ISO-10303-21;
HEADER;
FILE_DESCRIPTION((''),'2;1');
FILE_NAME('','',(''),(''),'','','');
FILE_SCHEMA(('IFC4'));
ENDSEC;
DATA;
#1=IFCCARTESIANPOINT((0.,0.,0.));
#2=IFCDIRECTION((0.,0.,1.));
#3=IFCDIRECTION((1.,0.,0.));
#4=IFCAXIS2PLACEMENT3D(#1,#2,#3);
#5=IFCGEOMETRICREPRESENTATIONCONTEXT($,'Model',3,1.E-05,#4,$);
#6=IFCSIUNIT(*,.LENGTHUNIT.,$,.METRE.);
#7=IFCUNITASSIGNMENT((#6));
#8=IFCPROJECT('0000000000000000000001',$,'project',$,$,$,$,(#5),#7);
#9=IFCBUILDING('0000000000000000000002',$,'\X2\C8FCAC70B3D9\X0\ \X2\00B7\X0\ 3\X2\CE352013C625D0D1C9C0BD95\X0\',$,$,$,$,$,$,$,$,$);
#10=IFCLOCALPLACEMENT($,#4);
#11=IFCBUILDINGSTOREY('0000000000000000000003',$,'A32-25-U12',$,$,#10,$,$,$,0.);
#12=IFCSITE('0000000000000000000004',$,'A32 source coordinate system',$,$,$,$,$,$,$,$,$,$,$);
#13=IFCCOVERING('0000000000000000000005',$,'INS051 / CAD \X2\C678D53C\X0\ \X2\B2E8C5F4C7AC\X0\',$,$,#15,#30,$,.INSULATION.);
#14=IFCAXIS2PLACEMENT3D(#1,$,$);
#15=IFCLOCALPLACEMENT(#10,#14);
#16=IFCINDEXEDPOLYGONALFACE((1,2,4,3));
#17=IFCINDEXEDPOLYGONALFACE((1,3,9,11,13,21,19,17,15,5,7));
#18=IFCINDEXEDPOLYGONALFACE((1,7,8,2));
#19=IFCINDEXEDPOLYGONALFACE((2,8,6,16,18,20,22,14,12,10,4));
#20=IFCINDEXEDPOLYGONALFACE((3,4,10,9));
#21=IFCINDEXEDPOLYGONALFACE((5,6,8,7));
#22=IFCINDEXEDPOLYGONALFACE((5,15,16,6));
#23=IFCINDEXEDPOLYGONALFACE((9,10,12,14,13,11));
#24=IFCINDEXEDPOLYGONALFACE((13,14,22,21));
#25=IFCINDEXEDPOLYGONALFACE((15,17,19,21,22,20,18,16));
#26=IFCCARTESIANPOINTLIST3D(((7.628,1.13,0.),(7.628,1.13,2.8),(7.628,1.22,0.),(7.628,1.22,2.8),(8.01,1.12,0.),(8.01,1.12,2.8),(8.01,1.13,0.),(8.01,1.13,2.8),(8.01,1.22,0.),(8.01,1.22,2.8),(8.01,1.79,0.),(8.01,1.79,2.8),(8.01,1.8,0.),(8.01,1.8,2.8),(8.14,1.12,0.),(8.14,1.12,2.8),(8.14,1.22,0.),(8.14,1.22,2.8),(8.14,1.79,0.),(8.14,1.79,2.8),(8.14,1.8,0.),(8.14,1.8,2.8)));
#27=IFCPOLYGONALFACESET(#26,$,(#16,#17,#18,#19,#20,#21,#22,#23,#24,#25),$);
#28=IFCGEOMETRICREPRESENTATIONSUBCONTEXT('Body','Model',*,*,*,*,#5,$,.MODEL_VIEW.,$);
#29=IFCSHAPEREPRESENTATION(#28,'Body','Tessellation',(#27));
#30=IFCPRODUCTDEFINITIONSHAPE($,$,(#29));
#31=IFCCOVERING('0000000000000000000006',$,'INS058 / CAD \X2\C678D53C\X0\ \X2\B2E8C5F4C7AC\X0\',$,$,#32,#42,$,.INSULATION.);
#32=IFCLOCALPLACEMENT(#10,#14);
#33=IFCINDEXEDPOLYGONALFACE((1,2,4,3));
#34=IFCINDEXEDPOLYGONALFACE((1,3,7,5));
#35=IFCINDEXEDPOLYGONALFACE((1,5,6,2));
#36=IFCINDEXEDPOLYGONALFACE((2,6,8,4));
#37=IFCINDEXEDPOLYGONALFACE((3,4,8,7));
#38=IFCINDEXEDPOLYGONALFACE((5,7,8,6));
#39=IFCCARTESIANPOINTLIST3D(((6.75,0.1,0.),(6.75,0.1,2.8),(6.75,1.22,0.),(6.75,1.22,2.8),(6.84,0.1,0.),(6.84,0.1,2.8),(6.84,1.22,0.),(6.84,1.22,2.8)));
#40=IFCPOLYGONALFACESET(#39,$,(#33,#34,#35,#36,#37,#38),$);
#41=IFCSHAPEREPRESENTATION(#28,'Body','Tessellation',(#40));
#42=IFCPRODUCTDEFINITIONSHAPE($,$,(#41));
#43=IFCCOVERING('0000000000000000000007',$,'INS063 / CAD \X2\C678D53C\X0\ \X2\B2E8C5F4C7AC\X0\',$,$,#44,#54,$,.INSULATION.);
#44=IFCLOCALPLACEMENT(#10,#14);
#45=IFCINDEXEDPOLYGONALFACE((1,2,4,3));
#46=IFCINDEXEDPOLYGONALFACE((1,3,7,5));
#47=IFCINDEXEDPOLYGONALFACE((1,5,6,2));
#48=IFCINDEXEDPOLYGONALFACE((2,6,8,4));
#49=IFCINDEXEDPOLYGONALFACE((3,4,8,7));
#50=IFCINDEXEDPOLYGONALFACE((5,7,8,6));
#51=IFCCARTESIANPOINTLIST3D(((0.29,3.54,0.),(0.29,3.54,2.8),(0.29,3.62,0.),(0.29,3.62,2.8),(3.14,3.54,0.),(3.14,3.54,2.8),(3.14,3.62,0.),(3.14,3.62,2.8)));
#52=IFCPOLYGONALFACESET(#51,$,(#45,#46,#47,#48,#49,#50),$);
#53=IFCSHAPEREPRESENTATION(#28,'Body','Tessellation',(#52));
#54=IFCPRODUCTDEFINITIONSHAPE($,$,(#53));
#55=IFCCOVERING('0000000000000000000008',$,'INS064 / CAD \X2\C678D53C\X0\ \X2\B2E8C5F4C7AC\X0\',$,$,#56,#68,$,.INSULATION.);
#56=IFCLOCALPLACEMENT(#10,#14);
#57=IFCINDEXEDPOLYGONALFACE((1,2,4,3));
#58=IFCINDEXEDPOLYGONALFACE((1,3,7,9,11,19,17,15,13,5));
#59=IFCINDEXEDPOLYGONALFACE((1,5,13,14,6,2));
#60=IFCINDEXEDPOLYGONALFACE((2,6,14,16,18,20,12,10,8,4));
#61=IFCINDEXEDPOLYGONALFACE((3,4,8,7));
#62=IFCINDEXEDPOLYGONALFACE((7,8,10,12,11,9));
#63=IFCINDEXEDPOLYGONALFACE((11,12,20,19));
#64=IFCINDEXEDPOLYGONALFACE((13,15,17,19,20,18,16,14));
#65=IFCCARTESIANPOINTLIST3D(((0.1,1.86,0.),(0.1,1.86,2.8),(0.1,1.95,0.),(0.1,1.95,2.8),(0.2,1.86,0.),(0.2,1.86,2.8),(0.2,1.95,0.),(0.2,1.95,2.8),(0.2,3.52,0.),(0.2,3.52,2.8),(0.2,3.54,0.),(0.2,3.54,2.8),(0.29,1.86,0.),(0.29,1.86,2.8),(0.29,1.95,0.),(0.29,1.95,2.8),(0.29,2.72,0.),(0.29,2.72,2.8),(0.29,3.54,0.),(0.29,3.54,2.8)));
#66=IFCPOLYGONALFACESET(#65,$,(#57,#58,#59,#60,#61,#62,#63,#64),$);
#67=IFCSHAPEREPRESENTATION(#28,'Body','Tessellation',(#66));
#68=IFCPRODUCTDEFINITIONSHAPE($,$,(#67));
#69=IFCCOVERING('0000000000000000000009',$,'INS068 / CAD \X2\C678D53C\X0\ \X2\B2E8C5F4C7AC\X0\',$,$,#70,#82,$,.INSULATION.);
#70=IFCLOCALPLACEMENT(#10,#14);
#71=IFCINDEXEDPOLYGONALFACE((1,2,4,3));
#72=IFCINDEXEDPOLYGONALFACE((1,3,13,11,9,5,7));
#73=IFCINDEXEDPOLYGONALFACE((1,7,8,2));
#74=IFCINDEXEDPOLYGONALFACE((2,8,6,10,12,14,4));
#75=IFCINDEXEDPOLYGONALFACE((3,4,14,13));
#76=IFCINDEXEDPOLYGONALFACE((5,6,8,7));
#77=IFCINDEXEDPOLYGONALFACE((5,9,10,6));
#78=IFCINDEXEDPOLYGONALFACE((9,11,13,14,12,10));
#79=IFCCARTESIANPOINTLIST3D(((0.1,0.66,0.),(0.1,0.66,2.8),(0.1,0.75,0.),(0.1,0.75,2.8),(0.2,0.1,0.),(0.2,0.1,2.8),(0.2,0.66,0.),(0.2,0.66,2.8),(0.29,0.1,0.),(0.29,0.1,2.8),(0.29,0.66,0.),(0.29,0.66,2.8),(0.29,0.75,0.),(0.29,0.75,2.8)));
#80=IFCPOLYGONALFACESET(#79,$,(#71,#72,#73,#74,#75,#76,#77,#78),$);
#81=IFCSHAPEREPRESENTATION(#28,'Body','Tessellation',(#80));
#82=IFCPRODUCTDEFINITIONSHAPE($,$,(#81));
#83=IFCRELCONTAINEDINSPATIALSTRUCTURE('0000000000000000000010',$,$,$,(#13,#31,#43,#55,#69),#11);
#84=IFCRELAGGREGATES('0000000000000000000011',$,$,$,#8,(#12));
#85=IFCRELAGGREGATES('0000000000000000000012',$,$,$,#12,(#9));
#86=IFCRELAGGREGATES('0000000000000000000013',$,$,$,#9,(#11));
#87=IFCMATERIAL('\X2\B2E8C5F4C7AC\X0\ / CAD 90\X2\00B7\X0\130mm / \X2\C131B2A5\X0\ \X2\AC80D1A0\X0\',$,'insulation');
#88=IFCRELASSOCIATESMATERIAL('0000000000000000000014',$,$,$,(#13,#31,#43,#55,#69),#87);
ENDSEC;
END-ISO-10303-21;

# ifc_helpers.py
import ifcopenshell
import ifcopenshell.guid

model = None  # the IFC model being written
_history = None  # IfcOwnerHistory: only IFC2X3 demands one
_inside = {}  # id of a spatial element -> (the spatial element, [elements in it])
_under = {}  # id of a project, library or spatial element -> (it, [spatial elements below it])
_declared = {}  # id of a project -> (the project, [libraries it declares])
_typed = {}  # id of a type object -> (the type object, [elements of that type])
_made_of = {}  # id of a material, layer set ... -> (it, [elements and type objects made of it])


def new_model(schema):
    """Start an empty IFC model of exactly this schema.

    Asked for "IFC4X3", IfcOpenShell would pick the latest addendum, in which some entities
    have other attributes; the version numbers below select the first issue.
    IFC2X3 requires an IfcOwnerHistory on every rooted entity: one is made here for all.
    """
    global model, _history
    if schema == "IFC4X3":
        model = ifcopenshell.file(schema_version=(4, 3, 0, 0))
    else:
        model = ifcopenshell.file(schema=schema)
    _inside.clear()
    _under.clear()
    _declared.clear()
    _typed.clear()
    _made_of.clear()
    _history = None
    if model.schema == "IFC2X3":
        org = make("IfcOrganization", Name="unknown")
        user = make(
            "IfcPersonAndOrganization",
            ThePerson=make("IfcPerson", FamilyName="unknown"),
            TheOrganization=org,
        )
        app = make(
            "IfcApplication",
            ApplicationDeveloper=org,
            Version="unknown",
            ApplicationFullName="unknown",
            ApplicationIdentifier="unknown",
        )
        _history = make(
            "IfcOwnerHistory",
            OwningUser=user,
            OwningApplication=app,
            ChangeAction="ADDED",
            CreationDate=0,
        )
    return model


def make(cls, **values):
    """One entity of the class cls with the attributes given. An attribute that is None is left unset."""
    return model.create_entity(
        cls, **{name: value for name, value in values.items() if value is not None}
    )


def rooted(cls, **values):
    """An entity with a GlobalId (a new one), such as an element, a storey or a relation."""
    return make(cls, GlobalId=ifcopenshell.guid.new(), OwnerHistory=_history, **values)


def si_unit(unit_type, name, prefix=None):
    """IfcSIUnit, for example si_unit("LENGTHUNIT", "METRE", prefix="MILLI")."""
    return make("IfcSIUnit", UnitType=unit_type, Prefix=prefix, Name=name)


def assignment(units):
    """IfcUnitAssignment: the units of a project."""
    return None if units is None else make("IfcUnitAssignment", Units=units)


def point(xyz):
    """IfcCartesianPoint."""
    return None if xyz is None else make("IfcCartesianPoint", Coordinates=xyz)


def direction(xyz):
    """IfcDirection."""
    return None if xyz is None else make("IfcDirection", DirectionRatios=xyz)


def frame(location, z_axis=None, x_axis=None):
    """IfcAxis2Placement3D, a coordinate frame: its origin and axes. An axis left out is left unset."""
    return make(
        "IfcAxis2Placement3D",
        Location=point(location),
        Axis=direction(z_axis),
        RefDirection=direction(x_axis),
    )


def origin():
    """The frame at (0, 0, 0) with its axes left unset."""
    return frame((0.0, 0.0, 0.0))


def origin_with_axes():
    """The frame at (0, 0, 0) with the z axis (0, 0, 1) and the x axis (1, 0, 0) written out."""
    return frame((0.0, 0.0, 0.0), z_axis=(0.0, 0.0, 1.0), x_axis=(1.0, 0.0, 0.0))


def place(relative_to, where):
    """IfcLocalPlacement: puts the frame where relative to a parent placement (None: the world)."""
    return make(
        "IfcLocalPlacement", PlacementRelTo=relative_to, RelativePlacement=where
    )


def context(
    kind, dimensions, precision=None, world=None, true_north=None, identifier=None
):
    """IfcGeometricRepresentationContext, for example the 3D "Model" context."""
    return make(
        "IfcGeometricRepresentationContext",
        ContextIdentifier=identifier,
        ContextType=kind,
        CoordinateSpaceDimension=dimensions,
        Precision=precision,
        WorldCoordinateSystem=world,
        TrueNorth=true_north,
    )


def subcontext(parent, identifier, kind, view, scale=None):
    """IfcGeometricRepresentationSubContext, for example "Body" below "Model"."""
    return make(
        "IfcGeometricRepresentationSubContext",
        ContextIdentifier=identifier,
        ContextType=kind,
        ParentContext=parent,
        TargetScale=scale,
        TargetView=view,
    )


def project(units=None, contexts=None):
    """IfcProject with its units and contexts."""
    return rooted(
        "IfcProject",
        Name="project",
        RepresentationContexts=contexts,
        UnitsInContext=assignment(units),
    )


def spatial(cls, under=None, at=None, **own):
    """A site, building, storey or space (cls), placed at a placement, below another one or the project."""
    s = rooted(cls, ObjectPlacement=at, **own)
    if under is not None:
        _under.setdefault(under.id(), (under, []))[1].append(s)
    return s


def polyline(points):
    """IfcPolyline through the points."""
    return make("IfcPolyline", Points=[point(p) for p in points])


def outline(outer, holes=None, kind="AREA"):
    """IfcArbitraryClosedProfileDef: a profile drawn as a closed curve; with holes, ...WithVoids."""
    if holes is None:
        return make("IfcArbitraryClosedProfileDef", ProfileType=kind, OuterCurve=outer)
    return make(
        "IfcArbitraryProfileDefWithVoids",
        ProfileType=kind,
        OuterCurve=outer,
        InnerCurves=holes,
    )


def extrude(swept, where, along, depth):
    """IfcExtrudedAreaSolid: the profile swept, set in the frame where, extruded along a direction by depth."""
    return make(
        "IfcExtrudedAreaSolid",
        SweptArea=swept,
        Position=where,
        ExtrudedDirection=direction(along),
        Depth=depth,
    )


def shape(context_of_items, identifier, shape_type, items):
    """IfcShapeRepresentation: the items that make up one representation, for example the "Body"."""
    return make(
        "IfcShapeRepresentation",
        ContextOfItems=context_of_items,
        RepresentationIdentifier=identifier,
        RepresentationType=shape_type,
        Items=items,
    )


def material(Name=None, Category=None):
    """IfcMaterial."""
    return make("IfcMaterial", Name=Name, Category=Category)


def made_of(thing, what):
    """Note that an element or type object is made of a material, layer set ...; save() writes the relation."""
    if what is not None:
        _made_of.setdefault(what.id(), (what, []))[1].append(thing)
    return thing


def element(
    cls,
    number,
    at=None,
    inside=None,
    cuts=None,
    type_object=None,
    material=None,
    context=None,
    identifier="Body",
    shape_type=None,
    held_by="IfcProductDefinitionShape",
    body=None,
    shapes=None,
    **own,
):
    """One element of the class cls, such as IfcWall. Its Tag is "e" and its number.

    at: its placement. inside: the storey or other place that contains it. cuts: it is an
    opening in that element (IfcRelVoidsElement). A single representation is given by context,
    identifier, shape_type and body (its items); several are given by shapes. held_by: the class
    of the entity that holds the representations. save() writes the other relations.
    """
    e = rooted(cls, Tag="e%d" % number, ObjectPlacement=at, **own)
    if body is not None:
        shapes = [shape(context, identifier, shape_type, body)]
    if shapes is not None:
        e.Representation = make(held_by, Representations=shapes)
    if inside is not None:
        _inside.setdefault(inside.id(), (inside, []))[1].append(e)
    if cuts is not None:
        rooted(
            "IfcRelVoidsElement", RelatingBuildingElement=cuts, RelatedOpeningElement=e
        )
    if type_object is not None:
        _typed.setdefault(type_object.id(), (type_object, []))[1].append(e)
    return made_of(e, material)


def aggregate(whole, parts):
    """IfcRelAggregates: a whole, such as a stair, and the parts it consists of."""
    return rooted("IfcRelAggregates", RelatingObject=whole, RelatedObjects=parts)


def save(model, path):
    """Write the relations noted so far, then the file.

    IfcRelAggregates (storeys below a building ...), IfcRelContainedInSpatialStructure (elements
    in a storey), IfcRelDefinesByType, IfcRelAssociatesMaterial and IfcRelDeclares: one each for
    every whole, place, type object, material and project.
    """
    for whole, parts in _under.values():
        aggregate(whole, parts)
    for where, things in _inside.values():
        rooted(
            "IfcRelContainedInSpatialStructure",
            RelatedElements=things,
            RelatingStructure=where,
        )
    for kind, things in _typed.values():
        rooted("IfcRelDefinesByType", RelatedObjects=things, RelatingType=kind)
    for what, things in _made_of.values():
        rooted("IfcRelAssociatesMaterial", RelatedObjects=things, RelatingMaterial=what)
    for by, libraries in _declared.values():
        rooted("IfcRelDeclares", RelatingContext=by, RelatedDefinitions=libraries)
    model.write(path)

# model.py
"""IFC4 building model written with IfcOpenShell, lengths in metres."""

from ifc_helpers import new_model, si_unit, origin, origin_with_axes, place, context, subcontext, project, spatial, polyline, outline, extrude, material, element, save


model = new_model("IFC4")

# Units and contexts
model_context = context("Model", 3, precision=1e-05, world=origin_with_axes())
body_context = subcontext(model_context, "Body", "Model", "MODEL_VIEW")
ifc_project = project(units=[si_unit("LENGTHUNIT", "METRE")], contexts=[model_context])

# Site, building, storey
storey_placement = place(None, origin_with_axes())
site = spatial("IfcSite", under=ifc_project, Name="A32 source coordinate system")
building = spatial("IfcBuilding", under=site, Name="주거동 · 3층–옥탑지붕")
storey = spatial("IfcBuildingStorey", under=building, at=storey_placement, Name="A32-25-U12", Elevation=0.0)

# Coverings
ifc_material = material(Name="단열재 / CAD 90·130mm / 성능 검토", Category="insulation")
covering_1_placement = place(storey_placement, origin_with_axes())
element("IfcCovering", 1, at=covering_1_placement, inside=storey, material=ifc_material, Name="INS051 / CAD 외피 단열재", PredefinedType="INSULATION", context=body_context, shape_type="SweptSolid", body=[
    extrude(outline(polyline([(8.14, 1.12), (8.01, 1.12), (8.01, 1.13), (7.628, 1.13), (7.628, 1.22), (8.01, 1.22), (8.01, 1.79), (8.01, 1.8), (8.14, 1.8), (8.14, 1.79), (8.14, 1.22), (8.14, 1.12)])), origin(), (0.0, 0.0, 1.0), 2.8),
])
covering_2_placement = place(storey_placement, origin_with_axes())
element("IfcCovering", 2, at=covering_2_placement, inside=storey, material=ifc_material, Name="INS058 / CAD 외피 단열재", PredefinedType="INSULATION", context=body_context, shape_type="SweptSolid", body=[
    extrude(outline(polyline([(6.75, 0.1), (6.75, 1.22), (6.84, 1.22), (6.84, 0.1), (6.75, 0.1)])), origin(), (0.0, 0.0, 1.0), 2.8),
])
covering_3_placement = place(storey_placement, origin_with_axes())
element("IfcCovering", 3, at=covering_3_placement, inside=storey, material=ifc_material, Name="INS063 / CAD 외피 단열재", PredefinedType="INSULATION", context=body_context, shape_type="SweptSolid", body=[
    extrude(outline(polyline([(0.29, 3.54), (0.29, 3.62), (3.14, 3.62), (3.14, 3.54), (0.29, 3.54)])), origin(), (0.0, 0.0, 1.0), 2.8),
])
covering_4_placement = place(storey_placement, origin_with_axes())
element("IfcCovering", 4, at=covering_4_placement, inside=storey, material=ifc_material, Name="INS064 / CAD 외피 단열재", PredefinedType="INSULATION", context=body_context, shape_type="SweptSolid", body=[
    extrude(outline(polyline([(0.1, 1.86), (0.1, 1.95), (0.2, 1.95), (0.2, 3.52), (0.2, 3.54), (0.29, 3.54), (0.29, 2.72), (0.29, 1.95), (0.29, 1.86), (0.2, 1.86), (0.1, 1.86)])), origin(), (0.0, 0.0, 1.0), 2.8),
])
covering_5_placement = place(storey_placement, origin_with_axes())
element("IfcCovering", 5, at=covering_5_placement, inside=storey, material=ifc_material, Name="INS068 / CAD 외피 단열재", PredefinedType="INSULATION", context=body_context, shape_type="SweptSolid", body=[
    extrude(outline(polyline([(0.2, 0.1), (0.2, 0.66), (0.1, 0.66), (0.1, 0.75), (0.29, 0.75), (0.29, 0.66), (0.29, 0.1), (0.2, 0.1)])), origin(), (0.0, 0.0, 1.0), 2.8),
])

save(model, "model.ifc")
